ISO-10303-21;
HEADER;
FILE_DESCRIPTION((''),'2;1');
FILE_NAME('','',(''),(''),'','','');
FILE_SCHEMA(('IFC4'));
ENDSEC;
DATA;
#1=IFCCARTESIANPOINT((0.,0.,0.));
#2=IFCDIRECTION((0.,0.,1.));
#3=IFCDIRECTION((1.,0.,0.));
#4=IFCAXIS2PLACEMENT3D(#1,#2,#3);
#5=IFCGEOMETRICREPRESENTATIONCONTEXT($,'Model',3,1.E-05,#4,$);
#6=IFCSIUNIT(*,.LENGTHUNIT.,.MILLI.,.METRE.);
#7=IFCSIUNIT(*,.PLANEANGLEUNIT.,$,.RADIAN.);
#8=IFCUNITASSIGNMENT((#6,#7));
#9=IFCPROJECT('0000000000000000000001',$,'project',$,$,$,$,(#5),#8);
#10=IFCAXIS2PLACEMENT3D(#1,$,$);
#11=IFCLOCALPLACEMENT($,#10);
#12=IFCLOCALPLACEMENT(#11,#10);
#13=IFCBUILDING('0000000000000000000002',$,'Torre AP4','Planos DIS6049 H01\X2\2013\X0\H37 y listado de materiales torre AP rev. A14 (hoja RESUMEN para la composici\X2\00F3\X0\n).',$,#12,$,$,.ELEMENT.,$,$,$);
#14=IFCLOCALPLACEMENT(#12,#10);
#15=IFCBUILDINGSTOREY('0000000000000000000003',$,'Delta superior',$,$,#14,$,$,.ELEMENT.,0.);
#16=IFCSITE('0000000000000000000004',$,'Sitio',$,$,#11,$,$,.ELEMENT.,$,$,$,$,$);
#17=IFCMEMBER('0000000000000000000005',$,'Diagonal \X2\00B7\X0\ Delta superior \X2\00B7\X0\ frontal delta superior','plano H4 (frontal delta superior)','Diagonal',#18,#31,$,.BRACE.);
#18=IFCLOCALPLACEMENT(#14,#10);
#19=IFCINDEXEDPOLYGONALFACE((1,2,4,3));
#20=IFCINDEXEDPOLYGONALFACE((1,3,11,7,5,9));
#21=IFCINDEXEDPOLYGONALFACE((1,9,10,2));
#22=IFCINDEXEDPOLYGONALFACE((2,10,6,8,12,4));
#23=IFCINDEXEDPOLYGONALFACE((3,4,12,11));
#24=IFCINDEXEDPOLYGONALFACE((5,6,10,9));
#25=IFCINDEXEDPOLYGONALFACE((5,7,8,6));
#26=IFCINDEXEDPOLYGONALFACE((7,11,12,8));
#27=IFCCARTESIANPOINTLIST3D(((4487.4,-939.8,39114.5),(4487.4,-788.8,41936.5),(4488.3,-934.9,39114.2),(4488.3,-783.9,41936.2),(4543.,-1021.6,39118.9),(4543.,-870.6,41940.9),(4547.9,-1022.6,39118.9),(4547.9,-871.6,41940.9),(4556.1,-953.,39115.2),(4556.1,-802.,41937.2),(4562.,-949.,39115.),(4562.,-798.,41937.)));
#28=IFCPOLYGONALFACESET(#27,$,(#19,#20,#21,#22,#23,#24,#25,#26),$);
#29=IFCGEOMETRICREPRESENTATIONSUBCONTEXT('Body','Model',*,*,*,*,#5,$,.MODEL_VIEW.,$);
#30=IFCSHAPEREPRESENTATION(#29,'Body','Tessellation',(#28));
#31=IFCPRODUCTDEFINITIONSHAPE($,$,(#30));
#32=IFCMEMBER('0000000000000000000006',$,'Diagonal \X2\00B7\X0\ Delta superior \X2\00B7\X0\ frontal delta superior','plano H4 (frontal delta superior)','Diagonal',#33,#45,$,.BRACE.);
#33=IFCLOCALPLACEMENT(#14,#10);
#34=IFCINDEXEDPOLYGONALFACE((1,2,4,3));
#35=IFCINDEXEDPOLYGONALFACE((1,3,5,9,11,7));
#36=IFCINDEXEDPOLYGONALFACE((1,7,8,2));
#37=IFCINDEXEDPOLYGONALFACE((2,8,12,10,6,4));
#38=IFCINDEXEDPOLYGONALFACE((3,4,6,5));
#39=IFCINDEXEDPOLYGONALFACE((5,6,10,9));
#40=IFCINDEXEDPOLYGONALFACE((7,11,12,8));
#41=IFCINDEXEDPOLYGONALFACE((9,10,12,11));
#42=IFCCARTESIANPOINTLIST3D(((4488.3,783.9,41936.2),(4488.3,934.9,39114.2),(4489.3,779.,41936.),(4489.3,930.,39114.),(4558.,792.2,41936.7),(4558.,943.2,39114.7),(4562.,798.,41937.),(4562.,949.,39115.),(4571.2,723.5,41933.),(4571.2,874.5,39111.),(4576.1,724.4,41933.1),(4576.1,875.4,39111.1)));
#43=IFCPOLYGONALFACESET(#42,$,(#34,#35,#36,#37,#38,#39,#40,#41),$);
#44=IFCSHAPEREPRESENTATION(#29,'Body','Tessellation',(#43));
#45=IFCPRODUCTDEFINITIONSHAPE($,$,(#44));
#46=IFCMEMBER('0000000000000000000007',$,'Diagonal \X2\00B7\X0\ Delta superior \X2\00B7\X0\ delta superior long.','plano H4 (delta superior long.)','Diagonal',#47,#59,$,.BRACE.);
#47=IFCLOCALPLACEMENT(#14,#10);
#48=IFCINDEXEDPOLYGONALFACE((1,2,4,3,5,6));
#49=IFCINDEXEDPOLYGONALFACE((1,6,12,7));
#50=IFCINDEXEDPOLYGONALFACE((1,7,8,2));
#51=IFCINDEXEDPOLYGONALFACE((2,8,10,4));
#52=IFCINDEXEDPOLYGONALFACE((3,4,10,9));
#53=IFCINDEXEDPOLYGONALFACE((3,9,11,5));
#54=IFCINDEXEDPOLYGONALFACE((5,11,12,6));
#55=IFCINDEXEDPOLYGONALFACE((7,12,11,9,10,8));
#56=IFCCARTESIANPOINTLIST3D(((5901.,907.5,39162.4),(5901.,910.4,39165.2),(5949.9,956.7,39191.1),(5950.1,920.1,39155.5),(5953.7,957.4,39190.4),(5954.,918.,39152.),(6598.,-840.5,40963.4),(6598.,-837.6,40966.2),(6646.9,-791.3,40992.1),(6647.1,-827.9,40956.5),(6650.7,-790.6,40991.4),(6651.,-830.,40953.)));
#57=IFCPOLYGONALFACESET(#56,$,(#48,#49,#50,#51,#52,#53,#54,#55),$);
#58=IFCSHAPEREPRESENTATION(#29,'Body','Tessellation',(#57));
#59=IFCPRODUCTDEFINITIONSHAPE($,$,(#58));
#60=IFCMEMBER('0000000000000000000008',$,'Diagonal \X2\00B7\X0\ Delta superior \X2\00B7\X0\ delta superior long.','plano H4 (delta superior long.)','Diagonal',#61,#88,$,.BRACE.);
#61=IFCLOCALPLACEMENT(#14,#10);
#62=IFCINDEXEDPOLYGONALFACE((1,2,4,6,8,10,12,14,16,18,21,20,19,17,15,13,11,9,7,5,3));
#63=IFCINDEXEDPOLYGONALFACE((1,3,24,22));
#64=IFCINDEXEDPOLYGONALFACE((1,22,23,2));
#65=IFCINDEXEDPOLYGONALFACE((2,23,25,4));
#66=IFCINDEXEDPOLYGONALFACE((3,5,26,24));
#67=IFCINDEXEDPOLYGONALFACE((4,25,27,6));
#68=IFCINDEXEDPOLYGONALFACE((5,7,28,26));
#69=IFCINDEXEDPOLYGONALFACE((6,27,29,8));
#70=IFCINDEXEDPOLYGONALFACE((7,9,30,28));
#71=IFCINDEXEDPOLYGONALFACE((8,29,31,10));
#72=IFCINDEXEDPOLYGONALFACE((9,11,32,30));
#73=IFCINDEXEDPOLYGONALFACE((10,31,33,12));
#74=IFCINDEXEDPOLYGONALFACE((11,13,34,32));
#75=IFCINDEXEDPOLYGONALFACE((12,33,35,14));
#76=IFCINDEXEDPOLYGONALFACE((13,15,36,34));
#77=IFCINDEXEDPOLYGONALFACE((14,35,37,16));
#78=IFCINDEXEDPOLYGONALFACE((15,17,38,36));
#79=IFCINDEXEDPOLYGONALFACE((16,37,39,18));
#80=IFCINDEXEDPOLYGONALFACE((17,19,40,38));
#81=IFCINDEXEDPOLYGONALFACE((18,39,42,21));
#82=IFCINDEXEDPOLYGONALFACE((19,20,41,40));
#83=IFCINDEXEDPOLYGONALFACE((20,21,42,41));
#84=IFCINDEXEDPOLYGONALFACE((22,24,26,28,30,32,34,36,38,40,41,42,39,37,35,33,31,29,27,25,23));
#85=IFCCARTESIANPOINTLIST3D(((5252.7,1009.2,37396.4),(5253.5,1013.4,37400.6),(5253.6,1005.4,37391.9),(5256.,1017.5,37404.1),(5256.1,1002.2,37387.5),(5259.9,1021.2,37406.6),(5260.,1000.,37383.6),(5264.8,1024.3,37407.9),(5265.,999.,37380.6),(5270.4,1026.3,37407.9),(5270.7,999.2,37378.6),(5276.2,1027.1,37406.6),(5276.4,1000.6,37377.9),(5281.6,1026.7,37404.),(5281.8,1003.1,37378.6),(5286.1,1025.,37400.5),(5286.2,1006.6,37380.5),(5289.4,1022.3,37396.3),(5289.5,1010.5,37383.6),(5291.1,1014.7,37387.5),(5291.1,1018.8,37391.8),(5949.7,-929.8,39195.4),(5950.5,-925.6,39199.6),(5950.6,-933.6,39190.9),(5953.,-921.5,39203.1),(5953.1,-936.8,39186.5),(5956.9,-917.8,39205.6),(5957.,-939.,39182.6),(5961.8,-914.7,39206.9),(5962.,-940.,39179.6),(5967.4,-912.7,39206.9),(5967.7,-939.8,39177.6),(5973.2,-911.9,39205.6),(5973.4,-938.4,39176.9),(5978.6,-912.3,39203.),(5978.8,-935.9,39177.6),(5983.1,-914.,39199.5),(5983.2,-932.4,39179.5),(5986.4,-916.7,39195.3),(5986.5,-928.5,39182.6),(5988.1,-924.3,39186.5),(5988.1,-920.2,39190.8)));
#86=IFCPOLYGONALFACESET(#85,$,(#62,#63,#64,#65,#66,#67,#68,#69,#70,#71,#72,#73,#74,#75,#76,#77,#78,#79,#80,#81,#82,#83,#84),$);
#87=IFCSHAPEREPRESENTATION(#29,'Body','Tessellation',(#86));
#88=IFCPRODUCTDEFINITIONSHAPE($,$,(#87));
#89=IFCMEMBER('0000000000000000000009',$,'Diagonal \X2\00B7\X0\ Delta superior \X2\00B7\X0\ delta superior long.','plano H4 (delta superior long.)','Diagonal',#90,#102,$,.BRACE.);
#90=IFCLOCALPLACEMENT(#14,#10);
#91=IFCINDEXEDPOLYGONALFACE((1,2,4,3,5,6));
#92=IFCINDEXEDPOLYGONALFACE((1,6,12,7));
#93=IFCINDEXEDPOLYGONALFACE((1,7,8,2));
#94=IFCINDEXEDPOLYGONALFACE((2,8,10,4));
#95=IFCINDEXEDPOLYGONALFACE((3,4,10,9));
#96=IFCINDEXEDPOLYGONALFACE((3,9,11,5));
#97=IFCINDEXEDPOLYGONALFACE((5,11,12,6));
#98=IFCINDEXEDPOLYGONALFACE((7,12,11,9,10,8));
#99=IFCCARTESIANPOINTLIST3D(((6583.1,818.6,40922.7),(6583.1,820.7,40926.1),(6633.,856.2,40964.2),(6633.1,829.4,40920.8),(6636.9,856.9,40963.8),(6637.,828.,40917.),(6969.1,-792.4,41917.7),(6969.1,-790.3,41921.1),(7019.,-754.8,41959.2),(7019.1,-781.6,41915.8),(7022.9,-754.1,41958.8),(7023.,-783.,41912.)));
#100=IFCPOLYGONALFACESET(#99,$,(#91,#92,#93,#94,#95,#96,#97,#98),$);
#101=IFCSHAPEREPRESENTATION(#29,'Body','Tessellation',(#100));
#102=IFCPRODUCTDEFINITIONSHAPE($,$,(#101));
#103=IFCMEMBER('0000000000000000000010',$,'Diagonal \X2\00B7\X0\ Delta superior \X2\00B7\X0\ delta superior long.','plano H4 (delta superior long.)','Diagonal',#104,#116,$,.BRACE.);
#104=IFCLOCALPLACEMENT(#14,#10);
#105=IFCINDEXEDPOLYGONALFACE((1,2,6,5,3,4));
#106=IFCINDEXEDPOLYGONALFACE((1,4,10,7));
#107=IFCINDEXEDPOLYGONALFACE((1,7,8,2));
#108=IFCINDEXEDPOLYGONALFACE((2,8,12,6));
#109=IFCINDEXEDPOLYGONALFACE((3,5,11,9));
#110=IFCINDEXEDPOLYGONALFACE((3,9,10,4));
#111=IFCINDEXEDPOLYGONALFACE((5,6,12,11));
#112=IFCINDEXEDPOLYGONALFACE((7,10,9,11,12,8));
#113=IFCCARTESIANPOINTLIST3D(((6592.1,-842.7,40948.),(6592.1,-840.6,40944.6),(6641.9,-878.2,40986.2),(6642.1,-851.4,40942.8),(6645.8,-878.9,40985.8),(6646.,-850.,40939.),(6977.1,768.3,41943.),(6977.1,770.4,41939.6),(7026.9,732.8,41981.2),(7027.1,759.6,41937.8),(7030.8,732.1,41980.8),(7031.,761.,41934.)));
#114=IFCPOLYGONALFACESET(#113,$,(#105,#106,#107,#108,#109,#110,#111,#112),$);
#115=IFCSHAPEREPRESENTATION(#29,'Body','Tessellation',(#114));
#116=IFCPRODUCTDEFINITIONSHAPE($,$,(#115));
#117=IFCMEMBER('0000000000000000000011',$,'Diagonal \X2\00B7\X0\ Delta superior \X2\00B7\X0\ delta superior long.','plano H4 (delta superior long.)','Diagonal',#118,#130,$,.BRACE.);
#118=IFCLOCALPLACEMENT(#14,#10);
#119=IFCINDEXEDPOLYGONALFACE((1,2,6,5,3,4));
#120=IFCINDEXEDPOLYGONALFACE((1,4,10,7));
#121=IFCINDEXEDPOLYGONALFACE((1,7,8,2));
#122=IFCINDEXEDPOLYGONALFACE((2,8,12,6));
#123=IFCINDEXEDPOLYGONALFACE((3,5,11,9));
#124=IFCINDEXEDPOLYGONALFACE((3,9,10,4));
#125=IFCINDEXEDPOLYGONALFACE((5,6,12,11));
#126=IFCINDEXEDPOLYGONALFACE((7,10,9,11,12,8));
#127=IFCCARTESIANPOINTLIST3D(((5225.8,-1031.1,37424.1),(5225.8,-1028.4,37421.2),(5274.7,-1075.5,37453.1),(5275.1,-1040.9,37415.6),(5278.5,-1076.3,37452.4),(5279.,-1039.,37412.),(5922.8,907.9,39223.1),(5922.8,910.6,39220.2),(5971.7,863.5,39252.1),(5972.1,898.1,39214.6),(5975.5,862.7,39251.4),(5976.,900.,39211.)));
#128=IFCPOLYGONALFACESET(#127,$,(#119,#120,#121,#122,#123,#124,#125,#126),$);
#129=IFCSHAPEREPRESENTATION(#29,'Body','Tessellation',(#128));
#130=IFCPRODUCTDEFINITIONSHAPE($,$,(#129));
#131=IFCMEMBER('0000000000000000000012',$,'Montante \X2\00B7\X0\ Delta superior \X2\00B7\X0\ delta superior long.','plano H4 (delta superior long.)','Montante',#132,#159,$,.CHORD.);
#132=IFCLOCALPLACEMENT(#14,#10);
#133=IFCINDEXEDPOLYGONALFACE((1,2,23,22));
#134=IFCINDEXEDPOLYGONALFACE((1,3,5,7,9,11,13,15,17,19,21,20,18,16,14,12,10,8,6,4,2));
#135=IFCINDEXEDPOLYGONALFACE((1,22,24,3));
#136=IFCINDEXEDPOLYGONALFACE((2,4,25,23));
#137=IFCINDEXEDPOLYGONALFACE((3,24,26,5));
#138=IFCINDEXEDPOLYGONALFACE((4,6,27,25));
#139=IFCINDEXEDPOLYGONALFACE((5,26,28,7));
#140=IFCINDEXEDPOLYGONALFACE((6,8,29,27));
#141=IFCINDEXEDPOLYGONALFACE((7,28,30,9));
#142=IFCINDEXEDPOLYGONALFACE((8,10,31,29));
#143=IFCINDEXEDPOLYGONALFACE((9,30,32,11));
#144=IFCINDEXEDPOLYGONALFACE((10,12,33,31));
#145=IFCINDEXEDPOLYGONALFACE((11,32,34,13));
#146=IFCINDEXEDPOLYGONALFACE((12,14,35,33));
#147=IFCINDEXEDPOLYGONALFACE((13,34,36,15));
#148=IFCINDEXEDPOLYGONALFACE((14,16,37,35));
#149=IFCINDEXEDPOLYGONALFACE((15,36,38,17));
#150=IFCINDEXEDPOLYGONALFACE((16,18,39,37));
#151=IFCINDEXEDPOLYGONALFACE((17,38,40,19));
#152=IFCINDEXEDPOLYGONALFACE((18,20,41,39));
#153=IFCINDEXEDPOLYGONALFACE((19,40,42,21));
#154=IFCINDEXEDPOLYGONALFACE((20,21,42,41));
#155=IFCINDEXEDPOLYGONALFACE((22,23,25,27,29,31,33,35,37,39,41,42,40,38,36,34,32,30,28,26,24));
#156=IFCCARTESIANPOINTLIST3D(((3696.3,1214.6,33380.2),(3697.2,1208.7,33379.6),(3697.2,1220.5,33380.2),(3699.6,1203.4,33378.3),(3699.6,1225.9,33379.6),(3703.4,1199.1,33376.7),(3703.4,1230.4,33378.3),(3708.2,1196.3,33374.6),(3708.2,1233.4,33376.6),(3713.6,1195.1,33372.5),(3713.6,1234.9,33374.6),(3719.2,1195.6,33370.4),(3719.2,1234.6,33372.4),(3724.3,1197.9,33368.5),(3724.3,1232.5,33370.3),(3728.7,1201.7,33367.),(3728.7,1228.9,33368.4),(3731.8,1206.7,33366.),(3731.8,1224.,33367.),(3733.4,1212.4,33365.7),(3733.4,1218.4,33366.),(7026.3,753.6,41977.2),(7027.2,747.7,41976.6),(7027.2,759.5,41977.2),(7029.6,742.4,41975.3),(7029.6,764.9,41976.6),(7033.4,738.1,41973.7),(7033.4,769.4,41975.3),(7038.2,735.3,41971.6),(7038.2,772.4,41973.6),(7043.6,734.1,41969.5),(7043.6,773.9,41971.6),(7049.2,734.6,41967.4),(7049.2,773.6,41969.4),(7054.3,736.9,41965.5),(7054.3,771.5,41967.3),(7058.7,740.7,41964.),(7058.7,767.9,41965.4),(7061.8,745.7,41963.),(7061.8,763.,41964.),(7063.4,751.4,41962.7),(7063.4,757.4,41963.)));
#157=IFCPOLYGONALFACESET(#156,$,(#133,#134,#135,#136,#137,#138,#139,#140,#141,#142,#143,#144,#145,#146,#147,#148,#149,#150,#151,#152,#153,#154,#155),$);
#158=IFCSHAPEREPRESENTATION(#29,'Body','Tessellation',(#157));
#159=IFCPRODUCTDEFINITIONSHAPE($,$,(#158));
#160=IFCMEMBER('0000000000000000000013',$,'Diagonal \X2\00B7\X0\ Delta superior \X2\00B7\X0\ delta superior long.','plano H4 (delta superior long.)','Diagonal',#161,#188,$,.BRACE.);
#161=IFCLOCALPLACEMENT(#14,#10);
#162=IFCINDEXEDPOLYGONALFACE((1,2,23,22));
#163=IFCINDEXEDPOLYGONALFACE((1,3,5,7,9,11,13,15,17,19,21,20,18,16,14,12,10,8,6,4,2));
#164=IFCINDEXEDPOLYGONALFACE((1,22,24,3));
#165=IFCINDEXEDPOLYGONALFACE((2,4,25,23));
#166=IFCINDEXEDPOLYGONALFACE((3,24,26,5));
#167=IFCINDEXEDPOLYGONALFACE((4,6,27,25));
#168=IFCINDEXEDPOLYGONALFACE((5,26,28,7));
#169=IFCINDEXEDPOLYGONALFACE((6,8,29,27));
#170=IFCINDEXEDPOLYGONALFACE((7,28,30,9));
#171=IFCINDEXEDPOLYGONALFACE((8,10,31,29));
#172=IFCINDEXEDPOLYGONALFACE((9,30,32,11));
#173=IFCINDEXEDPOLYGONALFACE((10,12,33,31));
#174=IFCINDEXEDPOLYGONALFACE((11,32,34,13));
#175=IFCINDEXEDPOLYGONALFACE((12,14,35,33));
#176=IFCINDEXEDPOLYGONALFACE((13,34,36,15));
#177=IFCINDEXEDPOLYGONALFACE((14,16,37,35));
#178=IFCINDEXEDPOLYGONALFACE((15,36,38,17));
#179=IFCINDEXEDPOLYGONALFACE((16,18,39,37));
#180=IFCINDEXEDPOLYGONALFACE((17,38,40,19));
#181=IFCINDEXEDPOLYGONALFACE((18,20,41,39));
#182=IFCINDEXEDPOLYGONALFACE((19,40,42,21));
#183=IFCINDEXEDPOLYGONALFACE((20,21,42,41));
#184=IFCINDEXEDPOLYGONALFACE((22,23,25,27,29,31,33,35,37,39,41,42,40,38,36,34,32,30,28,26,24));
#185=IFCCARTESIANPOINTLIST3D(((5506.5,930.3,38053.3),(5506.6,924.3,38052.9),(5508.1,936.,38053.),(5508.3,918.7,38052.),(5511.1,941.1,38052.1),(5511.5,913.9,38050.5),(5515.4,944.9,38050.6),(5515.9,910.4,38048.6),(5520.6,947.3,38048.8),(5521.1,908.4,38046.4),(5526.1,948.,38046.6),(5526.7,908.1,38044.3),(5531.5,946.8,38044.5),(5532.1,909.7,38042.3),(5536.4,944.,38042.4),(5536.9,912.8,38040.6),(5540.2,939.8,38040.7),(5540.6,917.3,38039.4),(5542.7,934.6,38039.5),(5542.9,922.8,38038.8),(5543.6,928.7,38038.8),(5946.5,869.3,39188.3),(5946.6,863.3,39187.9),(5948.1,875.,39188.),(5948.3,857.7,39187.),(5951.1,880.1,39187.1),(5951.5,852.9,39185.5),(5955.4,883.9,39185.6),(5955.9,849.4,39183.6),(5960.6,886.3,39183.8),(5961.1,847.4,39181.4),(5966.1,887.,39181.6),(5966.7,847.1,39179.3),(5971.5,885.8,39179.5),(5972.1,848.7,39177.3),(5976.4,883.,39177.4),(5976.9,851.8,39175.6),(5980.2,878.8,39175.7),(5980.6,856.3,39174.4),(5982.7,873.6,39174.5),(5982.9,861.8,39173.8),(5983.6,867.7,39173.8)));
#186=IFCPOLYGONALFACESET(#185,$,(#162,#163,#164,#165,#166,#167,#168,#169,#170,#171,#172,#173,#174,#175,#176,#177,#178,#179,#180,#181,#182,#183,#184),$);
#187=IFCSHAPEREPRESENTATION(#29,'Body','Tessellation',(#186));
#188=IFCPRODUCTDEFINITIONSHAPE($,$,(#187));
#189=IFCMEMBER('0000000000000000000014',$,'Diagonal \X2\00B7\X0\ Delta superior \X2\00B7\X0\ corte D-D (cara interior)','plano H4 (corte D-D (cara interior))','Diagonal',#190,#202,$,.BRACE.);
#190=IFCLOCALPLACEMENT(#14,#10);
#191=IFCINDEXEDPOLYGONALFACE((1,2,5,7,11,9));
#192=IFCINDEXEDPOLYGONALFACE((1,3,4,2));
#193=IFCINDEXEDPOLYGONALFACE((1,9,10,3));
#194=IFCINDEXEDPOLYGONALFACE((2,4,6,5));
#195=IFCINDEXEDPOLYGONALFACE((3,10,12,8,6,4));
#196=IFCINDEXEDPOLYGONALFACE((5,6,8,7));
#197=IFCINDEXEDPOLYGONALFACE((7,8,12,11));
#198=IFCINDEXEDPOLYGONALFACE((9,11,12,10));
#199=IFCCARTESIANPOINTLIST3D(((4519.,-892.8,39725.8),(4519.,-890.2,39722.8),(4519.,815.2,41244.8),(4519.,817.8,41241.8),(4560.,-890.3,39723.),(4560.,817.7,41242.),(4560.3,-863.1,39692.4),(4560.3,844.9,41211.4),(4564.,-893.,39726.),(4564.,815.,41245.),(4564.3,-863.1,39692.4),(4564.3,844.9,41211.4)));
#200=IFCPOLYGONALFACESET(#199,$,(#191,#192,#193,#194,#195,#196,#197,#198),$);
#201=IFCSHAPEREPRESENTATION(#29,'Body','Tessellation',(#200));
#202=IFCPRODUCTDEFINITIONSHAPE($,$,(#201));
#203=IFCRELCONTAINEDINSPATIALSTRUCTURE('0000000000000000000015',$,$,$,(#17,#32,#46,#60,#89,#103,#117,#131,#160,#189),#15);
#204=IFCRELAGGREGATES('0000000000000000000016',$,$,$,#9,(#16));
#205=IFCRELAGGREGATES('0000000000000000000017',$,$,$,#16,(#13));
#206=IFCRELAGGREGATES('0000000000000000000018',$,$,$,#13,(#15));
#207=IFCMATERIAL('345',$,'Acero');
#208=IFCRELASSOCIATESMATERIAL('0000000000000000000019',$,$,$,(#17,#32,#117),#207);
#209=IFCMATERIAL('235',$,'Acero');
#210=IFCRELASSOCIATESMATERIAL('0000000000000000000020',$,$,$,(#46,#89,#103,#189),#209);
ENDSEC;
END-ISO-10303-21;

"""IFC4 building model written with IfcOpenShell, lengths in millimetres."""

from ifc_helpers import new_model, si_unit, frame, frame_2d, origin, origin_with_axes, place, context, subcontext, project, spatial, circle, l_section, extrude, material, element, save


model = new_model("IFC4")

# Units and contexts
model_context = context("Model", 3, precision=1e-05, world=origin_with_axes())
body_context = subcontext(model_context, "Body", "Model", "MODEL_VIEW")
ifc_project = project(units=[si_unit("LENGTHUNIT", "METRE", prefix="MILLI"), si_unit("PLANEANGLEUNIT", "RADIAN")], contexts=[model_context])

# Site, building, storey
site_placement = place(None, origin())
site = spatial("IfcSite", under=ifc_project, at=site_placement, Name="Sitio", CompositionType="ELEMENT")
building_placement = place(site_placement, origin())
building = spatial("IfcBuilding", under=site, at=building_placement, Name="Torre AP4", Description="Planos DIS6049 H01–H37 y listado de materiales torre AP rev. A14 (hoja RESUMEN para la composición).", CompositionType="ELEMENT")
storey_placement = place(building_placement, origin())
storey = spatial("IfcBuildingStorey", under=building, at=storey_placement, Name="Delta superior", CompositionType="ELEMENT", Elevation=0.0)

# Members
ifc_material_1 = material(Name="235", Category="Acero")
ifc_material_2 = material(Name="345", Category="Acero")
for number, where, z_axis, x_axis, name in (
    (1, (4562.0, -949.0, 39115.0), (0.0, 0.053432, 0.998572), (-0.982208, 0.187529, -0.010034), "Diagonal · Delta superior · frontal delta superior"),
    (2, (4562.0, 949.0, 39115.0), (0.0, -0.053432, 0.998572), (-0.982208, -0.187529, -0.010034), "Diagonal · Delta superior · frontal delta superior"),
):
    element("IfcMember", number, at=place(storey_placement, frame(where, z_axis=z_axis, x_axis=x_axis)), inside=storey, material=ifc_material_2, Name=name, Description="plano H4 (frontal delta superior)", ObjectType="Diagonal", PredefinedType="BRACE", context=body_context, shape_type="SweptSolid", body=[
        extrude(l_section(Depth=75.0, Width=75.0, Thickness=5.0, at=frame_2d((37.5, 37.5))), None, (0.0, 0.0, 1.0), 2826.0),
    ])
member_1_placement = place(storey_placement, frame((6651.0, -830.0, 40953.0), z_axis=(-0.267584, 0.671072, -0.691419), x_axis=(-0.963521, -0.190088, 0.188396)))
element("IfcMember", 3, at=member_1_placement, inside=storey, material=ifc_material_1, Name="Diagonal · Delta superior · delta superior long.", Description="plano H4 (delta superior long.)", ObjectType="Diagonal", PredefinedType="BRACE", context=body_context, shape_type="SweptSolid", body=[
    extrude(l_section(Depth=55.0, Width=55.0, Thickness=4.0, at=frame_2d((27.5, 27.5))), None, (0.0, 0.0, 1.0), 2604.8),
])
member_2_placement = place(storey_placement, frame((5969.0, -926.0, 39192.0), z_axis=(-0.254816, 0.708877, -0.657695), x_axis=(-0.966975, -0.190493, 0.169325)))
element("IfcMember", 4, at=member_2_placement, inside=storey, Name="Diagonal · Delta superior · delta superior long.", Description="plano H4 (delta superior long.)", ObjectType="Diagonal", PredefinedType="BRACE", context=body_context, shape_type="SweptSolid", body=[
    extrude(circle(Radius=20.0), None, (0.0, 0.0, 1.0), 2735.3),
])
member_3_placement = place(storey_placement, frame((7023.0, -783.0, 41912.0), z_axis=(-0.199747, 0.833659, -0.514892), x_axis=(-0.979846, -0.170873, 0.103461)))
element("IfcMember", 5, at=member_3_placement, inside=storey, material=ifc_material_1, Name="Diagonal · Delta superior · delta superior long.", Description="plano H4 (delta superior long.)", ObjectType="Diagonal", PredefinedType="BRACE", context=body_context, shape_type="SweptSolid", body=[
    extrude(l_section(Depth=55.0, Width=55.0, Thickness=4.0, at=frame_2d((27.5, 27.5))), None, (0.0, 0.0, 1.0), 1932.4),
])
member_4_placement = place(storey_placement, frame((6646.0, -850.0, 40939.0), z_axis=(0.19925, 0.833745, 0.514945), x_axis=(-0.979943, 0.171353, 0.101736)))
element("IfcMember", 6, at=member_4_placement, inside=storey, material=ifc_material_1, Name="Diagonal · Delta superior · delta superior long.", Description="plano H4 (delta superior long.)", ObjectType="Diagonal", PredefinedType="BRACE", context=body_context, shape_type="SweptSolid", body=[
    extrude(l_section(Depth=55.0, Width=55.0, Thickness=4.0, at=frame_2d((27.5, 27.5))), None, (0.0, 0.0, 1.0), 1932.2),
])
member_5_placement = place(storey_placement, frame((5279.0, -1039.0, 37412.0), z_axis=(0.254816, 0.708877, 0.657695), x_axis=(-0.966953, 0.192686, 0.166953)))
element("IfcMember", 7, at=member_5_placement, inside=storey, material=ifc_material_2, Name="Diagonal · Delta superior · delta superior long.", Description="plano H4 (delta superior long.)", ObjectType="Diagonal", PredefinedType="BRACE", context=body_context, shape_type="SweptSolid", body=[
    extrude(l_section(Depth=55.0, Width=55.0, Thickness=4.0, at=frame_2d((27.5, 27.5))), None, (0.0, 0.0, 1.0), 2735.3),
])
for number, where, z_axis, x_axis, name in (
    (8, (3715.0, 1215.0, 33373.0), (0.360744, -0.049941, 0.931327), (-0.932665, -0.019317, 0.360227), "Montante · Delta superior · delta superior long."),
):
    element("IfcMember", number, at=place(storey_placement, frame(where, z_axis=z_axis, x_axis=x_axis)), inside=storey, Name=name, Description="plano H4 (delta superior long.)", ObjectType="Montante", PredefinedType="CHORD", context=body_context, shape_type="SweptSolid", body=[
        extrude(circle(Radius=20.0), None, (0.0, 0.0, 1.0), 9230.9),
    ])
member_6_placement = place(storey_placement, frame((5525.0, 928.0, 38046.0), z_axis=(0.361002, -0.050048, 0.931221), x_axis=(-0.919866, -0.183339, 0.346747)))
element("IfcMember", 9, at=member_6_placement, inside=storey, Name="Diagonal · Delta superior · delta superior long.", Description="plano H4 (delta superior long.)", ObjectType="Diagonal", PredefinedType="BRACE", context=body_context, shape_type="SweptSolid", body=[
    extrude(circle(Radius=20.0), None, (0.0, 0.0, 1.0), 1218.8),
])
member_7_placement = place(storey_placement, frame((4564.0, 815.0, 41245.0), z_axis=(0.0, -0.74724, -0.664554), x_axis=(-0.999984, 0.003774, -0.004243)))
element("IfcMember", 10, at=member_7_placement, inside=storey, material=ifc_material_1, Name="Diagonal · Delta superior · corte D-D (cara interior)", Description="plano H4 (corte D-D (cara interior))", ObjectType="Diagonal", PredefinedType="BRACE", context=body_context, shape_type="SweptSolid", body=[
    extrude(l_section(Depth=45.0, Width=45.0, Thickness=4.0, at=frame_2d((22.5, 22.5))), None, (0.0, 0.0, 1.0), 2285.7),
])

save(model, "model.ifc")
